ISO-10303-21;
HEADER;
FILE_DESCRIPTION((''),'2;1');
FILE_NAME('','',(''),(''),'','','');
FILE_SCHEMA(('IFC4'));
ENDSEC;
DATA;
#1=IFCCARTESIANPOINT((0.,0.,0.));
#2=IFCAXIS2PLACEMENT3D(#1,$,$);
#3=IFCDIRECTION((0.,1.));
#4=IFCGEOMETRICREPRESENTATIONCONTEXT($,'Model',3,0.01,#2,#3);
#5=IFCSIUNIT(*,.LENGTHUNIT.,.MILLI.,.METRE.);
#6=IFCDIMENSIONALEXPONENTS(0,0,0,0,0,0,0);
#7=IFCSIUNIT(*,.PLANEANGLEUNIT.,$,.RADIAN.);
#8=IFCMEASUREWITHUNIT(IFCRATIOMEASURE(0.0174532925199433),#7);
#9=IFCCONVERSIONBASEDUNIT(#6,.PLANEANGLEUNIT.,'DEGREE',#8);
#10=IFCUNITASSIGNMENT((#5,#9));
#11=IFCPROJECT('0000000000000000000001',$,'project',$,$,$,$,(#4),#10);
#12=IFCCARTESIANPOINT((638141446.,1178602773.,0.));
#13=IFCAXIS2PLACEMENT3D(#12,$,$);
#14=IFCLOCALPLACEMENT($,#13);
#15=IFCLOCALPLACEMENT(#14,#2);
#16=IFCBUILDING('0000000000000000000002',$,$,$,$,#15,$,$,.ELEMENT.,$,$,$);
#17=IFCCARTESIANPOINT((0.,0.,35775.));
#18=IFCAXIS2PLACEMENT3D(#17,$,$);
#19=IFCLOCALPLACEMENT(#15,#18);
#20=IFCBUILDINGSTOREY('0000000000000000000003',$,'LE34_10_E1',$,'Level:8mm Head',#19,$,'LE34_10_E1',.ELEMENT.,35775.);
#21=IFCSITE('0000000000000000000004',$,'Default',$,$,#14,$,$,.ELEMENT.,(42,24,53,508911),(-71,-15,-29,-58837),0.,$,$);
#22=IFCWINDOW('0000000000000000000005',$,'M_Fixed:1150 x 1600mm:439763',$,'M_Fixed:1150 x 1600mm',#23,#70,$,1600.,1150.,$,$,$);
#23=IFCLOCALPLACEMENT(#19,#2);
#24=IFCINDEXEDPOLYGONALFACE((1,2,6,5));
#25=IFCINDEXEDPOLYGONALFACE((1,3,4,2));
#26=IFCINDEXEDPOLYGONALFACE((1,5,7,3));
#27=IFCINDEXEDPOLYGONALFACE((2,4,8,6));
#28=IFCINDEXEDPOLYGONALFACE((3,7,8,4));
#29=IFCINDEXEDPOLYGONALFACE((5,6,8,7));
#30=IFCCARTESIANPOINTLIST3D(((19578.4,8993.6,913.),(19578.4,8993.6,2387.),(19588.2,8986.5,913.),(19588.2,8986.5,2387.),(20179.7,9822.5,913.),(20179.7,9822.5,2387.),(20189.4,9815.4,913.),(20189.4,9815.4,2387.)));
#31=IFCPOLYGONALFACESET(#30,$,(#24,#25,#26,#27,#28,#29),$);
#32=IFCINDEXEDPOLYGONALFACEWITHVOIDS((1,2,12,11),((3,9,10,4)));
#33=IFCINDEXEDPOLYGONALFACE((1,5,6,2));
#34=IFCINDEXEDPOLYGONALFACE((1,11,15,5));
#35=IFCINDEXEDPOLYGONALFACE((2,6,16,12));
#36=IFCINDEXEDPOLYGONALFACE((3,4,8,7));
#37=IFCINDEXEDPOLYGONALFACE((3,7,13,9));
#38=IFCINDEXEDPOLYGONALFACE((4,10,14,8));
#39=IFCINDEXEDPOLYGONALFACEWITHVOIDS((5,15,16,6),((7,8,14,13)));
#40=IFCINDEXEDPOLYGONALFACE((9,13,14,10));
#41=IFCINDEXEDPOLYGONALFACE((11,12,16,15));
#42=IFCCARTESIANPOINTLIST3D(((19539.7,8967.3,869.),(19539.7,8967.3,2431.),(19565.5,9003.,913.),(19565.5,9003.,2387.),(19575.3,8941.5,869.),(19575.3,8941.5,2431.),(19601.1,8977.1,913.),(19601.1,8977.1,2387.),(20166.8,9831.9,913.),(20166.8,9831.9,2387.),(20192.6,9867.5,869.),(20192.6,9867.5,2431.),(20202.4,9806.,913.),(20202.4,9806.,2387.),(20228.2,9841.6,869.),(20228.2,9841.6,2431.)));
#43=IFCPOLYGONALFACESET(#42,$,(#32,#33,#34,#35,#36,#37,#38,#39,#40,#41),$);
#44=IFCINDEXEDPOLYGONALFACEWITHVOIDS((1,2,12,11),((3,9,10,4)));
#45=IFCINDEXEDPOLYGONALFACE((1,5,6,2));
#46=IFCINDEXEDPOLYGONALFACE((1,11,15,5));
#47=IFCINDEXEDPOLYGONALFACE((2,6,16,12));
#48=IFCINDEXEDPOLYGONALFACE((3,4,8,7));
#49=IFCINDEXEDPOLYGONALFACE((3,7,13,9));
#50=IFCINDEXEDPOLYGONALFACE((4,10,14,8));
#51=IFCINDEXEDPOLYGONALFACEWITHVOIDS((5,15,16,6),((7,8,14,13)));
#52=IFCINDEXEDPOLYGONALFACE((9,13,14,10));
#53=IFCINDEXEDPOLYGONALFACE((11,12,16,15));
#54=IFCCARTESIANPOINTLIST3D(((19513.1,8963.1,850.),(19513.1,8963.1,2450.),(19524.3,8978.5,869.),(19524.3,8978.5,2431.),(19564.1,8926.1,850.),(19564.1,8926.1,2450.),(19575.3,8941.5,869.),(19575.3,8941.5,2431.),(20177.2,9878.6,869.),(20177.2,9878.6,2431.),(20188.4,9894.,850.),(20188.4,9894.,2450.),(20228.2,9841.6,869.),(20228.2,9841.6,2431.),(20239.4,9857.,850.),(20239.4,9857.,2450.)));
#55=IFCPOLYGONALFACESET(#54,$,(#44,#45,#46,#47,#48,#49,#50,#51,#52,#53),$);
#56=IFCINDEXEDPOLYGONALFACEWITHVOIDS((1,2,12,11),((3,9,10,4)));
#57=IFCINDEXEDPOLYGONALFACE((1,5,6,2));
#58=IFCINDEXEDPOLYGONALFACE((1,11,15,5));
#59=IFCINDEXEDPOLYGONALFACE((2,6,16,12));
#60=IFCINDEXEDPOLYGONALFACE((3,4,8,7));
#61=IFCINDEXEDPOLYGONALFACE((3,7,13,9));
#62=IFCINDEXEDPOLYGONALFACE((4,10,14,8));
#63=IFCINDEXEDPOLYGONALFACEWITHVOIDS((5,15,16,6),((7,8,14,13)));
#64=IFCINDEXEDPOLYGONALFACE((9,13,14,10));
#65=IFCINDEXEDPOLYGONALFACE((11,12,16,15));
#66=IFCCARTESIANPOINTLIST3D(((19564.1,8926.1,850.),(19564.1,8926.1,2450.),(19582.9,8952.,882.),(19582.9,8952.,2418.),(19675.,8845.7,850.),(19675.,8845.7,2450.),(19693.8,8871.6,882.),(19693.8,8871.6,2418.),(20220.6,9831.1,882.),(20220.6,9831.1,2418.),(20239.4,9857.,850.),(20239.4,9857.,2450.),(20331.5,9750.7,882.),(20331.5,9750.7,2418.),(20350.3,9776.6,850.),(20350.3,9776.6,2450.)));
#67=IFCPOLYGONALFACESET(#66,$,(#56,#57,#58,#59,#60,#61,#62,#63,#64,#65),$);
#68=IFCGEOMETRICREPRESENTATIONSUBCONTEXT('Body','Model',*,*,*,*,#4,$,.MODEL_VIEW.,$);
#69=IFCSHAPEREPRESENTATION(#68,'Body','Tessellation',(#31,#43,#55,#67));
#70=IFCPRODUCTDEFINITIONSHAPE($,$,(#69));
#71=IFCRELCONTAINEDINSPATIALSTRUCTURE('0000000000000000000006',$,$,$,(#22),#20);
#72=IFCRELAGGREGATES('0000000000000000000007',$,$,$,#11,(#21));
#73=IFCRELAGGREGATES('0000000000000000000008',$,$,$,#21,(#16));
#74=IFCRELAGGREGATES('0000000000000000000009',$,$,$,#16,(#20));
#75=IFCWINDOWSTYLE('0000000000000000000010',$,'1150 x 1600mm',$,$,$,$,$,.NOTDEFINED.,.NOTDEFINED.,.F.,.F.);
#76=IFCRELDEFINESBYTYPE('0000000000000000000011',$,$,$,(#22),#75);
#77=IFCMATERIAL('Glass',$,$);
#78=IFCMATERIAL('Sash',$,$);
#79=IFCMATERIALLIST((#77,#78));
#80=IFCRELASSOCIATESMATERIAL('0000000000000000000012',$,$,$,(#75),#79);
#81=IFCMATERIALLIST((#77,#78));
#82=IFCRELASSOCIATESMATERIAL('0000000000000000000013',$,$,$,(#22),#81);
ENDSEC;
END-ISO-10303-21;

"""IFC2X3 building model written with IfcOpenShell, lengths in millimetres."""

from ifc_helpers import new_model, entity, si_unit, converted_unit, direction, frame, frame_2d, origin, place, context, subcontext, project, spatial, polyline, rectangle, outline, extrude, source, transform, mapped, material, material_list, type_object, type_shapes, element, save


model = new_model("IFC2X3")

# Units and contexts
model_context = context("Model", 3, precision=0.01, world=origin(), true_north=direction((0.0, 1.0)))
body_context = subcontext(model_context, "Body", "Model", "MODEL_VIEW")
ifc_project = project(units=[si_unit("LENGTHUNIT", "METRE", prefix="MILLI"), converted_unit("PLANEANGLEUNIT", "DEGREE", entity("IfcRatioMeasure", 0.0174532925199433), si_unit("PLANEANGLEUNIT", "RADIAN"), dimensions=[0, 0, 0, 0, 0, 0, 0])], contexts=[model_context])

# Site, building, storey
site_placement = place(None, frame((638141446.0, 1178602773.0, 0.0)))
site = spatial("IfcSite", under=ifc_project, at=site_placement, Name="Default", CompositionType="ELEMENT", RefLatitude=(42, 24, 53, 508911), RefLongitude=(-71, -15, -29, -58837), RefElevation=0.0)
building_placement = place(site_placement, origin())
building = spatial("IfcBuilding", under=site, at=building_placement, CompositionType="ELEMENT")
storey_placement = place(building_placement, frame((0.0, 0.0, 35775.0)))
storey = spatial("IfcBuildingStorey", under=building, at=storey_placement, Name="LE34_10_E1", ObjectType="Level:8mm Head", LongName="LE34_10_E1", CompositionType="ELEMENT", Elevation=35775.0)

# Shared definitions
ifc_material_1 = material(Name="Glass")
ifc_material_2 = material(Name="Sash")

# Window
ifc_material_list_1 = material_list([ifc_material_1, ifc_material_2])
ifc_material_list_2 = material_list([ifc_material_1, ifc_material_2])
window_style_1 = type_object("IfcWindowStyle", Name="1150 x 1600mm", ConstructionType="NOTDEFINED", OperationType="NOTDEFINED", ParameterTakesPrecedence=False, Sizeable=False, material=ifc_material_list_2)
shared_shape_1 = source(origin(), body_context, "Body", "SweptSolid", [
    extrude(rectangle(XDim=12.0, YDim=1024.0, at=frame_2d((0.0, 0.0), x_axis=(1.0, 0.0))), frame((575.0, 269.0, 63.0), z_axis=(0.0, 0.0, 1.0), x_axis=(0.0, -1.0, 0.0)), (0.0, 0.0, 1.0), 1474.0),
    extrude(outline(polyline([(-556.0, -781.0), (556.0, -781.0), (556.0, 781.0), (-556.0, 781.0), (-556.0, -781.0)]), holes=[polyline([(-512.0, -737.0), (-512.0, 737.0), (512.0, 737.0), (512.0, -737.0), (-512.0, -737.0)])]), frame((575.0, 247.0, 800.0), z_axis=(0.0, 1.0, 0.0), x_axis=(1.0, 0.0, 0.0)), (0.0, 0.0, 1.0), 44.0),
    extrude(outline(polyline([(-575.0, -800.0), (575.0, -800.0), (575.0, 800.0), (-575.0, 800.0), (-575.0, -800.0)]), holes=[polyline([(-556.0, -781.0), (-556.0, 781.0), (556.0, 781.0), (556.0, -781.0), (-556.0, -781.0)])]), frame((575.0, 247.0, 800.0), z_axis=(0.0, 1.0, 0.0), x_axis=(1.0, 0.0, 0.0)), (0.0, 0.0, 1.0), 63.0),
    extrude(outline(polyline([(-575.0, -800.0), (575.0, -800.0), (575.0, 800.0), (-575.0, 800.0), (-575.0, -800.0)]), holes=[polyline([(-543.0, -768.0), (-543.0, 768.0), (543.0, 768.0), (543.0, -768.0), (-543.0, -768.0)])]), frame((575.0, 110.0, 800.0), z_axis=(0.0, 1.0, 0.0), x_axis=(1.0, 0.0, 0.0)), (0.0, 0.0, 1.0), 137.0),
])
type_shapes(window_style_1, [shared_shape_1])
window_1_placement = place(storey_placement, frame((19764.1, 8781.1, 850.0), z_axis=(0.0, 0.0, 1.0), x_axis=(0.587164, 0.809468, 0.0)))
element("IfcWindow", 1, at=window_1_placement, inside=storey, type_object=window_style_1, material=ifc_material_list_1, Name="M_Fixed:1150 x 1600mm:439763", ObjectType="M_Fixed:1150 x 1600mm", OverallHeight=1600.0, OverallWidth=1150.0, context=body_context, shape_type="MappedRepresentation", body=[
    mapped(shared_shape_1, transform((0.0, 0.0, 0.0), scale=1.0)),
])

save(model, "model.ifc")
